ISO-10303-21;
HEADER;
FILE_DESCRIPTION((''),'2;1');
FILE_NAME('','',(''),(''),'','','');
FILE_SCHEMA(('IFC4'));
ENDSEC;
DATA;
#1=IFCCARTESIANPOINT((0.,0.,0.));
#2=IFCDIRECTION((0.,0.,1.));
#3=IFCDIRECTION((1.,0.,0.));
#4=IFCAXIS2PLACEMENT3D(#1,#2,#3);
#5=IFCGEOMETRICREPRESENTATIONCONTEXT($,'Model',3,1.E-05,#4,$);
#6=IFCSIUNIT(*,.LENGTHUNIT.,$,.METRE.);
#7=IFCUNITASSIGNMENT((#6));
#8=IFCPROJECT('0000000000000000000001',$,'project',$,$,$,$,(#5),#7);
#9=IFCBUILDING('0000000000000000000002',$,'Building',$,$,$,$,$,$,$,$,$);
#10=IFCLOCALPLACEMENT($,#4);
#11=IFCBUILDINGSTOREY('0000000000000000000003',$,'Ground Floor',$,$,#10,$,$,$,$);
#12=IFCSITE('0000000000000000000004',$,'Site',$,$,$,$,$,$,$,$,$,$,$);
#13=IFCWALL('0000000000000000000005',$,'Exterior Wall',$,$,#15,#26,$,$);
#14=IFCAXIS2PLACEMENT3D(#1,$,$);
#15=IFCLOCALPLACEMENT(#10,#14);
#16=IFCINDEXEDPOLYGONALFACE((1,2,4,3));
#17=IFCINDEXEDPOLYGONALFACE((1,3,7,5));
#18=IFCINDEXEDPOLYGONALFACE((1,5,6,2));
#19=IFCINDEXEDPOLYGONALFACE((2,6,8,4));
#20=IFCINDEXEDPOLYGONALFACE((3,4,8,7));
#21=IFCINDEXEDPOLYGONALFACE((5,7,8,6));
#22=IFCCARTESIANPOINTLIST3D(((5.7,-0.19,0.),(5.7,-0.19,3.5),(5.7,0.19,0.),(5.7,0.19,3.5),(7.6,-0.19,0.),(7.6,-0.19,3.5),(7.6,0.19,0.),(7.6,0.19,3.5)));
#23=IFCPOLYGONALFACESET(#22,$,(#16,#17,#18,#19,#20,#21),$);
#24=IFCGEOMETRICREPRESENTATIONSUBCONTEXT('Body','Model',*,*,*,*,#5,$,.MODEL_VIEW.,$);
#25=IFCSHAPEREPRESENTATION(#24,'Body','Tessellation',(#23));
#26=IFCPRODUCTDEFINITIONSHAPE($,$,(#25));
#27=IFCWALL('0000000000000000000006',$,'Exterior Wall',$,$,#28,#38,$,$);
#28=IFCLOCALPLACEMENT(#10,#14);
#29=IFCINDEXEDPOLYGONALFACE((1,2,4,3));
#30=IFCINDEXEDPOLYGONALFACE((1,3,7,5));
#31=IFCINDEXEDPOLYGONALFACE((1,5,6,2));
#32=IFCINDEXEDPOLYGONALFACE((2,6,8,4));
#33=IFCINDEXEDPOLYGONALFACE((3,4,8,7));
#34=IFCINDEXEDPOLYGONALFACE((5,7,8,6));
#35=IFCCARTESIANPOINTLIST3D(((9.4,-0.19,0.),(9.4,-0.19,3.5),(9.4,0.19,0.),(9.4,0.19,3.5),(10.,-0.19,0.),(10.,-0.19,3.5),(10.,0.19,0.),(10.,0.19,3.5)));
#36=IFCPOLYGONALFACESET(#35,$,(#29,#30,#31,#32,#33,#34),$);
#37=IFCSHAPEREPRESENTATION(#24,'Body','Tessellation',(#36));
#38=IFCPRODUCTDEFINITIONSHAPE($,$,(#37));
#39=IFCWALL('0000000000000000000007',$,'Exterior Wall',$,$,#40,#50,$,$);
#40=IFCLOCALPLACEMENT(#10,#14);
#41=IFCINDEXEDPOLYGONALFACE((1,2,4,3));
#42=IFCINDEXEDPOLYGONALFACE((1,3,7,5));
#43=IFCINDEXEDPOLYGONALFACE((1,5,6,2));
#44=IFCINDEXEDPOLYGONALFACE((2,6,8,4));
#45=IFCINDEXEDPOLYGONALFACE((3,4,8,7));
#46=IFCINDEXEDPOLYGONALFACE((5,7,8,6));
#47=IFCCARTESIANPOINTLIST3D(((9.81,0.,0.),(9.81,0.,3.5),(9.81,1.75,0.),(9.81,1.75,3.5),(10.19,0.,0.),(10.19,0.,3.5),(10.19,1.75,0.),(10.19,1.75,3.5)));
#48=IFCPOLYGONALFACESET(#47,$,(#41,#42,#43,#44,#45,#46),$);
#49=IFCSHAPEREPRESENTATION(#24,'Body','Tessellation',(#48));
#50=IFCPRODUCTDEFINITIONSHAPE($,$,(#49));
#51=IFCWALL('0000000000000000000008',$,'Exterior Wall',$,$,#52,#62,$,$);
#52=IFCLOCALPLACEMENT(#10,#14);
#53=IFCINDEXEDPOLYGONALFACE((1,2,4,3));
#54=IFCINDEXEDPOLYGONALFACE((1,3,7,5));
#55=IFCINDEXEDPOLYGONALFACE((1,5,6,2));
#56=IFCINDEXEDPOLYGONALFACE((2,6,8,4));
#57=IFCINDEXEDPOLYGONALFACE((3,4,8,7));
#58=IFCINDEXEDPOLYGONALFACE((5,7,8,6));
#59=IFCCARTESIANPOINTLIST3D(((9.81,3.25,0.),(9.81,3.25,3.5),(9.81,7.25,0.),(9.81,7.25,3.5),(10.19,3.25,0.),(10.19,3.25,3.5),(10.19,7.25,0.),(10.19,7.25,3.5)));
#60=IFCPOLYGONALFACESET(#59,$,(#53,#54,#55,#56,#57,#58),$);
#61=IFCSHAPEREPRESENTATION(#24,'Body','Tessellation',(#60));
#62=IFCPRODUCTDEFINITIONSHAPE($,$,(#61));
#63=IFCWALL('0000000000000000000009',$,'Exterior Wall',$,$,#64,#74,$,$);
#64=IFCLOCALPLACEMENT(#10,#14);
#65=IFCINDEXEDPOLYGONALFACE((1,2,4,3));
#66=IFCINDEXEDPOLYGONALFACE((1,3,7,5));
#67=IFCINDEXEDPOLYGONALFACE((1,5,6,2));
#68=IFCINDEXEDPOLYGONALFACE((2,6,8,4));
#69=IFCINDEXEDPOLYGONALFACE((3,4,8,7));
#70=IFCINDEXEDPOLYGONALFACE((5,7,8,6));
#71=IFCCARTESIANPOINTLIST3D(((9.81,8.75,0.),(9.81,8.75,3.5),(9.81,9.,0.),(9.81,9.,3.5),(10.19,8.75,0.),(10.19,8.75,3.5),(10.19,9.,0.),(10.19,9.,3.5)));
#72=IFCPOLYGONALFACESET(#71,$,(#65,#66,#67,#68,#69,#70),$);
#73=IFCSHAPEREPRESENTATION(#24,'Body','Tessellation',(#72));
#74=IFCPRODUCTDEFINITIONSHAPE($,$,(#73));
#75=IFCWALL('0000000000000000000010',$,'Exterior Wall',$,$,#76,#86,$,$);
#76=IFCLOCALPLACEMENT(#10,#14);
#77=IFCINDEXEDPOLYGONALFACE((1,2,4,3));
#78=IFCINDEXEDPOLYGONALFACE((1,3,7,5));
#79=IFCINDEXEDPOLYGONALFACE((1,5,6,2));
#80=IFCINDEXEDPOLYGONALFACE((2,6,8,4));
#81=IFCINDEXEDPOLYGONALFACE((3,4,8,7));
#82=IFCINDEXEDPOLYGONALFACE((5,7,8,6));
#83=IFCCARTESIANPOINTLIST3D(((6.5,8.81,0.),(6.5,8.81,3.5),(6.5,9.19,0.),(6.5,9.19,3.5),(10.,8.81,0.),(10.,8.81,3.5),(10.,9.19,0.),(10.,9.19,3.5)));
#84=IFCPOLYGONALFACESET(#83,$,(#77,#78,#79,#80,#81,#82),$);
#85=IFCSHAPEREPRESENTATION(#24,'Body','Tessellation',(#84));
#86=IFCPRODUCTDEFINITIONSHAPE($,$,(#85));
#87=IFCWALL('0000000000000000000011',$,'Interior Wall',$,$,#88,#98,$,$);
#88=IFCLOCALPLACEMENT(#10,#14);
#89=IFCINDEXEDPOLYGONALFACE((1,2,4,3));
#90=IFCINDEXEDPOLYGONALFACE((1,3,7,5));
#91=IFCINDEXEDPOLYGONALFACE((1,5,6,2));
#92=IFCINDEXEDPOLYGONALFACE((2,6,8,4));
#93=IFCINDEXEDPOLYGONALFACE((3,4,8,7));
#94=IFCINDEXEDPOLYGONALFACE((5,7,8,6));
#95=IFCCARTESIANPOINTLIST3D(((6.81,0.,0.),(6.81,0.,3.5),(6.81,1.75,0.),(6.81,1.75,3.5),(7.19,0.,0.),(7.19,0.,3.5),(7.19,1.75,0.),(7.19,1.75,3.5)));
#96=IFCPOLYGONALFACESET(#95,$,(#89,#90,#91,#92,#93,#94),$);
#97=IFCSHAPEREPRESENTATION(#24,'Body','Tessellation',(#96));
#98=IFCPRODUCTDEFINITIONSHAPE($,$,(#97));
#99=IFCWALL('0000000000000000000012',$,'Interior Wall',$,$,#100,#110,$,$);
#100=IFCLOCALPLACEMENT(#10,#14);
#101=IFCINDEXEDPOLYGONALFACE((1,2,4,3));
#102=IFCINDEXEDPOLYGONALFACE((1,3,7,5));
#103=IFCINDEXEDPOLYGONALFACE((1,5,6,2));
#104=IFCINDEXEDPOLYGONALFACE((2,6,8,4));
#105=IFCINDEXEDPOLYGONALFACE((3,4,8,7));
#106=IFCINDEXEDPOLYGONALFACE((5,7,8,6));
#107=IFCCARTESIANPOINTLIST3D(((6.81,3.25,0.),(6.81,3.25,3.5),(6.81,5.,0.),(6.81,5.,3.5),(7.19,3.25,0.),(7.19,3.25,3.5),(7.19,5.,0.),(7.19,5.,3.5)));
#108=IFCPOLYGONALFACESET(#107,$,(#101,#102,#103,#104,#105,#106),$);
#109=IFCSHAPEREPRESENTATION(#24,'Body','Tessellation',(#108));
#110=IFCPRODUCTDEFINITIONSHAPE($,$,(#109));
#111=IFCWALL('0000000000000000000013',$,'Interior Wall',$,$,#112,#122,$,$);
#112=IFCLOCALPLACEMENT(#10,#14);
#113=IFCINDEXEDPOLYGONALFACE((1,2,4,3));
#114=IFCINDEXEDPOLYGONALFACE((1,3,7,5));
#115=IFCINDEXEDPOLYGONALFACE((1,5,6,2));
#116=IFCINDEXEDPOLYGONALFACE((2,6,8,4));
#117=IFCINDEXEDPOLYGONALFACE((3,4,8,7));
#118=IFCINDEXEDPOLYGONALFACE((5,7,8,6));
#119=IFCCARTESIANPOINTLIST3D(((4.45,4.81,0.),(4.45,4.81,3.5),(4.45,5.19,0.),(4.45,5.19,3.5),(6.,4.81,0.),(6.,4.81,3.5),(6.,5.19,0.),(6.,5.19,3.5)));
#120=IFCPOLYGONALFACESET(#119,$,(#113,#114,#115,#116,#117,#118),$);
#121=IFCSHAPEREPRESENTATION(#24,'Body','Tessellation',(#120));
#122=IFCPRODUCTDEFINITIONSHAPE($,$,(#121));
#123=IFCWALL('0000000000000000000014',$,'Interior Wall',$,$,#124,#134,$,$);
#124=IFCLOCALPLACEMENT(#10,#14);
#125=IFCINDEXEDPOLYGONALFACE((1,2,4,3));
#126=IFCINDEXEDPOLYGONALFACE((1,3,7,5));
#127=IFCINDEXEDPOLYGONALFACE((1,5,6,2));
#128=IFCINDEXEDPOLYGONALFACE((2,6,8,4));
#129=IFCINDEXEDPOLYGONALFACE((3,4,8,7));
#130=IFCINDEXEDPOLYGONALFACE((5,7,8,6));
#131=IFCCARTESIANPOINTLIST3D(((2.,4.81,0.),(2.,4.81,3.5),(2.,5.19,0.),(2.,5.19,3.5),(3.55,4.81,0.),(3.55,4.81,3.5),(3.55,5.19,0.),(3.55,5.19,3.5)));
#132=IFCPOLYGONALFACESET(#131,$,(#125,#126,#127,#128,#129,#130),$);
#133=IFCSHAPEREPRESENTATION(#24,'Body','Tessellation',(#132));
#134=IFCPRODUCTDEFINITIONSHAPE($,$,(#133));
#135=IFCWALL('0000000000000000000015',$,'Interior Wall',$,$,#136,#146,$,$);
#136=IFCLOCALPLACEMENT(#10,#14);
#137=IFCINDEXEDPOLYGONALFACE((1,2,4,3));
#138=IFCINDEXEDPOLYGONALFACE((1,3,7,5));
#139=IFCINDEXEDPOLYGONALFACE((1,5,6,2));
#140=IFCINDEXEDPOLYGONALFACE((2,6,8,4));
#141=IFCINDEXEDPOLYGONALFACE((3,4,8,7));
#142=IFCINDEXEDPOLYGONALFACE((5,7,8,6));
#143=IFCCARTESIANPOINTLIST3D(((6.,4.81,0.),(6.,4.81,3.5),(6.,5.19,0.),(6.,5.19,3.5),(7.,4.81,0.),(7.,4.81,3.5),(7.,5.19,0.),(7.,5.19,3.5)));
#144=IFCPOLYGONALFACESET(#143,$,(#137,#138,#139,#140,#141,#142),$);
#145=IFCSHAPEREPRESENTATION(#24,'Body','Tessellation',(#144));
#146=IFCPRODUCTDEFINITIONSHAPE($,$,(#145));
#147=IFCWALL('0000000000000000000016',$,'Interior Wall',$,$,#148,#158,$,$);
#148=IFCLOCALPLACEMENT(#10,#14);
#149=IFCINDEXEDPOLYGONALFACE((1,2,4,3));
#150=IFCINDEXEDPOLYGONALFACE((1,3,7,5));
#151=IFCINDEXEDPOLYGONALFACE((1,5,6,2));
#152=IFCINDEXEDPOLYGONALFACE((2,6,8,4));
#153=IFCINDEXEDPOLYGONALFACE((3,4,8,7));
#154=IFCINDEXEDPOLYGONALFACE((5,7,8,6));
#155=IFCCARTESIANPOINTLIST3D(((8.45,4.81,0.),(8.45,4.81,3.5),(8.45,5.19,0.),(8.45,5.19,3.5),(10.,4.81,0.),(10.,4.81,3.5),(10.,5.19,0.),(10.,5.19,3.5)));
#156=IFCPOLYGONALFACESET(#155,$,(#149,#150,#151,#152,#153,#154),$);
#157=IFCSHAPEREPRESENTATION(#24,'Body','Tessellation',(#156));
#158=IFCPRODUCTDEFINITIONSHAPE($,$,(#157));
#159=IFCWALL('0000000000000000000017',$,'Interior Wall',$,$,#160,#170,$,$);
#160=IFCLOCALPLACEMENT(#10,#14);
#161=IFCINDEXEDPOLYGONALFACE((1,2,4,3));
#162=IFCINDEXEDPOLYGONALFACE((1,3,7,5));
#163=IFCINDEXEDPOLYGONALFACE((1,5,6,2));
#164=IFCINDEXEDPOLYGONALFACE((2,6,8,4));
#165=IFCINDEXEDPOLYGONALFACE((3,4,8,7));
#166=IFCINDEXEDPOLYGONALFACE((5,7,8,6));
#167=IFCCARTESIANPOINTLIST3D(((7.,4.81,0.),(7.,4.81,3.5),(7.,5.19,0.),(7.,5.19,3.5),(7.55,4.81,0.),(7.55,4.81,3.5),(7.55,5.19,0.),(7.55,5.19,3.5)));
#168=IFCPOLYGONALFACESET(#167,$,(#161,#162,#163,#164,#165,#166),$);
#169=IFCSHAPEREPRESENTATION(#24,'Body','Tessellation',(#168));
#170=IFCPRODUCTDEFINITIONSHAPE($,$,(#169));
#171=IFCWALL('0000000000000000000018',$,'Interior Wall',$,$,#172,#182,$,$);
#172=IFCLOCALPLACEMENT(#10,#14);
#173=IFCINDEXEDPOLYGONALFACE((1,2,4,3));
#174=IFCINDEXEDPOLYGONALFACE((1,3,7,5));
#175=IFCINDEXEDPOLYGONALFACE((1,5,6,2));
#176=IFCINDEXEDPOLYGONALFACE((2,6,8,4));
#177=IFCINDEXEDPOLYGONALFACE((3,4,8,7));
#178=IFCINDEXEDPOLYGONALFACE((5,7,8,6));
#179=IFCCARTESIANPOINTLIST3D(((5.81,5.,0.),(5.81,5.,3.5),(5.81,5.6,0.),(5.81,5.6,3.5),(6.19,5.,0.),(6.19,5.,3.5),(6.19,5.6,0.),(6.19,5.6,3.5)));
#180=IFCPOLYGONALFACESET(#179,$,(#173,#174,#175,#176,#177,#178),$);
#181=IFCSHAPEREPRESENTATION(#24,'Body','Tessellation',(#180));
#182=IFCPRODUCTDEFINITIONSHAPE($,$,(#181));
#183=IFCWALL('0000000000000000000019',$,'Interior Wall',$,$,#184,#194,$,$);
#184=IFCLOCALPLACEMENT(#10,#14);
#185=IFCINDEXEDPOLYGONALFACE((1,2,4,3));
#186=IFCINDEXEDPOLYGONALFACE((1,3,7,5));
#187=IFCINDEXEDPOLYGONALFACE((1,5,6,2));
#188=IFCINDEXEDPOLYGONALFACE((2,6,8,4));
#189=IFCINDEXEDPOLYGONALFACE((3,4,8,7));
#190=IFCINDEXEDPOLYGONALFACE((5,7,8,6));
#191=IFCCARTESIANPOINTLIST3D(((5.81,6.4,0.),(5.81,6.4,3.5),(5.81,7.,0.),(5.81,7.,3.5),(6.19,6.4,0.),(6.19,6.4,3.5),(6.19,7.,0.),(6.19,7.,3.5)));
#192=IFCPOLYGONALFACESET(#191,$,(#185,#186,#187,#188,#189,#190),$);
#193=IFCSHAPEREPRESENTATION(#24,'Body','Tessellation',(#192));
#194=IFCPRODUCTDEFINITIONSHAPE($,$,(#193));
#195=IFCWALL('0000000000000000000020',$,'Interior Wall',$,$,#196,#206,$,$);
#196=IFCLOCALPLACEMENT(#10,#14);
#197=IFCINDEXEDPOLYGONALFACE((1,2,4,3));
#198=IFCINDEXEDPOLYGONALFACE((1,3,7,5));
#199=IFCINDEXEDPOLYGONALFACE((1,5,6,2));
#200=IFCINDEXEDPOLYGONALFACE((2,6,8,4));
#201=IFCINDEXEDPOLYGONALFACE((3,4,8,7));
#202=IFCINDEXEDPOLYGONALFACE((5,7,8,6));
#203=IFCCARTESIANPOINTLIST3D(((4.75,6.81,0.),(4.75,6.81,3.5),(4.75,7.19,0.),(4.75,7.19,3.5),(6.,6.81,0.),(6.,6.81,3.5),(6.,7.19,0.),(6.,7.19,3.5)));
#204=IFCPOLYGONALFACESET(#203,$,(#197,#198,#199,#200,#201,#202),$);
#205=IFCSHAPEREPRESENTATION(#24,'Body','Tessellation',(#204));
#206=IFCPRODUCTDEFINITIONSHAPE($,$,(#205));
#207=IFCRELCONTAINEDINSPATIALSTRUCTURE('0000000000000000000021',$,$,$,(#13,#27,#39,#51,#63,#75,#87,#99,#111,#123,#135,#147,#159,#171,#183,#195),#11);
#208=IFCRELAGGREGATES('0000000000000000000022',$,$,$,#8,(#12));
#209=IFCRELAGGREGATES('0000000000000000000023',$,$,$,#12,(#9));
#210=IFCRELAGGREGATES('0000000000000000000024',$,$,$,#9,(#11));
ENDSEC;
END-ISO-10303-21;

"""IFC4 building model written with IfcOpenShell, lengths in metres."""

from ifc_helpers import new_model, si_unit, frame, origin_with_axes, place, context, subcontext, project, spatial, indexed_curve, outline, extrude, element, save


model = new_model("IFC4")

# Units and contexts
model_context = context("Model", 3, precision=1e-05, world=origin_with_axes())
body_context = subcontext(model_context, "Body", "Model", "MODEL_VIEW")
ifc_project = project(units=[si_unit("LENGTHUNIT", "METRE")], contexts=[model_context])

# Site, building, storey
site = spatial("IfcSite", under=ifc_project, Name="Site")
building = spatial("IfcBuilding", under=site, Name="Building")
storey_placement = place(None, origin_with_axes())
storey = spatial("IfcBuildingStorey", under=building, at=storey_placement, Name="Ground Floor")

# Walls
wall_1_placement = place(storey_placement, frame((5.7, 0.0, 0.0), z_axis=(0.0, 0.0, 1.0), x_axis=(1.0, 0.0, 0.0)))
element("IfcWall", 1, at=wall_1_placement, inside=storey, Name="Exterior Wall", context=body_context, shape_type="SweptSolid", body=[
    extrude(outline(indexed_curve([(0.0, 0.0), (0.0, 0.38), (1.9, 0.38), (1.9, 0.0), (0.0, 0.0)], self_intersect=False)), frame((0.0, -0.19, 0.0), z_axis=(0.0, 0.0, 1.0), x_axis=(1.0, 0.0, 0.0)), (0.0, 0.0, 1.0), 3.5),
])
wall_2_placement = place(storey_placement, frame((9.4, 0.0, 0.0), z_axis=(0.0, 0.0, 1.0), x_axis=(1.0, 0.0, 0.0)))
element("IfcWall", 2, at=wall_2_placement, inside=storey, Name="Exterior Wall", context=body_context, shape_type="SweptSolid", body=[
    extrude(outline(indexed_curve([(0.0, 0.0), (0.0, 0.38), (0.6, 0.38), (0.6, 0.0), (0.0, 0.0)], self_intersect=False)), frame((0.0, -0.19, 0.0), z_axis=(0.0, 0.0, 1.0), x_axis=(1.0, 0.0, 0.0)), (0.0, 0.0, 1.0), 3.5),
])
wall_3_placement = place(storey_placement, frame((10.0, 0.0, 0.0), z_axis=(0.0, 0.0, 1.0), x_axis=(0.0, 1.0, 0.0)))
element("IfcWall", 3, at=wall_3_placement, inside=storey, Name="Exterior Wall", context=body_context, shape_type="SweptSolid", body=[
    extrude(outline(indexed_curve([(0.0, 0.0), (0.0, 0.38), (1.75, 0.38), (1.75, 0.0), (0.0, 0.0)], self_intersect=False)), frame((0.0, -0.19, 0.0), z_axis=(0.0, 0.0, 1.0), x_axis=(1.0, 0.0, 0.0)), (0.0, 0.0, 1.0), 3.5),
])
wall_4_placement = place(storey_placement, frame((10.0, 3.25, 0.0), z_axis=(0.0, 0.0, 1.0), x_axis=(0.0, 1.0, 0.0)))
element("IfcWall", 4, at=wall_4_placement, inside=storey, Name="Exterior Wall", context=body_context, shape_type="SweptSolid", body=[
    extrude(outline(indexed_curve([(0.0, 0.0), (0.0, 0.38), (4.0, 0.38), (4.0, 0.0), (0.0, 0.0)], self_intersect=False)), frame((0.0, -0.19, 0.0), z_axis=(0.0, 0.0, 1.0), x_axis=(1.0, 0.0, 0.0)), (0.0, 0.0, 1.0), 3.5),
])
wall_5_placement = place(storey_placement, frame((10.0, 8.75, 0.0), z_axis=(0.0, 0.0, 1.0), x_axis=(0.0, 1.0, 0.0)))
element("IfcWall", 5, at=wall_5_placement, inside=storey, Name="Exterior Wall", context=body_context, shape_type="SweptSolid", body=[
    extrude(outline(indexed_curve([(0.0, 0.0), (0.0, 0.38), (0.25, 0.38), (0.25, 0.0), (0.0, 0.0)], self_intersect=False)), frame((0.0, -0.19, 0.0), z_axis=(0.0, 0.0, 1.0), x_axis=(1.0, 0.0, 0.0)), (0.0, 0.0, 1.0), 3.5),
])
wall_6_placement = place(storey_placement, frame((10.0, 9.0, 0.0), z_axis=(0.0, 0.0, 1.0), x_axis=(-1.0, 0.0, 0.0)))
element("IfcWall", 6, at=wall_6_placement, inside=storey, Name="Exterior Wall", context=body_context, shape_type="SweptSolid", body=[
    extrude(outline(indexed_curve([(0.0, 0.0), (0.0, 0.38), (3.5, 0.38), (3.5, 0.0), (0.0, 0.0)], self_intersect=False)), frame((0.0, -0.19, 0.0), z_axis=(0.0, 0.0, 1.0), x_axis=(1.0, 0.0, 0.0)), (0.0, 0.0, 1.0), 3.5),
])
for number, where, z_axis, x_axis, name in (
    (7, (7.0, 0.0, 0.0), (0.0, 0.0, 1.0), (0.0, 1.0, 0.0), "Interior Wall"),
    (8, (7.0, 3.25, 0.0), (0.0, 0.0, 1.0), (0.0, 1.0, 0.0), "Interior Wall"),
):
    element("IfcWall", number, at=place(storey_placement, frame(where, z_axis=z_axis, x_axis=x_axis)), inside=storey, Name=name, context=body_context, shape_type="SweptSolid", body=[
        extrude(outline(indexed_curve([(0.0, 0.0), (0.0, 0.38), (1.75, 0.38), (1.75, 0.0), (0.0, 0.0)], self_intersect=False)), frame((0.0, -0.19, 0.0), z_axis=(0.0, 0.0, 1.0), x_axis=(1.0, 0.0, 0.0)), (0.0, 0.0, 1.0), 3.5),
    ])
for number, where, z_axis, x_axis, name in (
    (9, (6.0, 5.0, 0.0), (0.0, 0.0, 1.0), (-1.0, 0.0, 0.0), "Interior Wall"),
    (10, (3.55, 5.0, 0.0), (0.0, 0.0, 1.0), (-1.0, 0.0, 0.0), "Interior Wall"),
):
    element("IfcWall", number, at=place(storey_placement, frame(where, z_axis=z_axis, x_axis=x_axis)), inside=storey, Name=name, context=body_context, shape_type="SweptSolid", body=[
        extrude(outline(indexed_curve([(0.0, 0.0), (0.0, 0.38), (1.55, 0.38), (1.55, 0.0), (0.0, 0.0)], self_intersect=False)), frame((0.0, -0.19, 0.0), z_axis=(0.0, 0.0, 1.0), x_axis=(1.0, 0.0, 0.0)), (0.0, 0.0, 1.0), 3.5),
    ])
wall_7_placement = place(storey_placement, frame((7.0, 5.0, 0.0), z_axis=(0.0, 0.0, 1.0), x_axis=(-1.0, 0.0, 0.0)))
element("IfcWall", 11, at=wall_7_placement, inside=storey, Name="Interior Wall", context=body_context, shape_type="SweptSolid", body=[
    extrude(outline(indexed_curve([(0.0, 0.0), (0.0, 0.38), (1.0, 0.38), (1.0, 0.0), (0.0, 0.0)], self_intersect=False)), frame((0.0, -0.19, 0.0), z_axis=(0.0, 0.0, 1.0), x_axis=(1.0, 0.0, 0.0)), (0.0, 0.0, 1.0), 3.5),
])
wall_8_placement = place(storey_placement, frame((10.0, 5.0, 0.0), z_axis=(0.0, 0.0, 1.0), x_axis=(-1.0, 0.0, 0.0)))
element("IfcWall", 12, at=wall_8_placement, inside=storey, Name="Interior Wall", context=body_context, shape_type="SweptSolid", body=[
    extrude(outline(indexed_curve([(0.0, 0.0), (0.0, 0.38), (1.55, 0.38), (1.55, 0.0), (0.0, 0.0)], self_intersect=False)), frame((0.0, -0.19, 0.0), z_axis=(0.0, 0.0, 1.0), x_axis=(1.0, 0.0, 0.0)), (0.0, 0.0, 1.0), 3.5),
])
wall_9_placement = place(storey_placement, frame((7.55, 5.0, 0.0), z_axis=(0.0, 0.0, 1.0), x_axis=(-1.0, 0.0, 0.0)))
element("IfcWall", 13, at=wall_9_placement, inside=storey, Name="Interior Wall", context=body_context, shape_type="SweptSolid", body=[
    extrude(outline(indexed_curve([(0.0, 0.0), (0.0, 0.38), (0.55, 0.38), (0.55, 0.0), (0.0, 0.0)], self_intersect=False)), frame((0.0, -0.19, 0.0), z_axis=(0.0, 0.0, 1.0), x_axis=(1.0, 0.0, 0.0)), (0.0, 0.0, 1.0), 3.5),
])
for number, where, z_axis, x_axis, name in (
    (14, (6.0, 5.0, 0.0), (0.0, 0.0, 1.0), (0.0, 1.0, 0.0), "Interior Wall"),
    (15, (6.0, 6.4, 0.0), (0.0, 0.0, 1.0), (0.0, 1.0, 0.0), "Interior Wall"),
):
    element("IfcWall", number, at=place(storey_placement, frame(where, z_axis=z_axis, x_axis=x_axis)), inside=storey, Name=name, context=body_context, shape_type="SweptSolid", body=[
        extrude(outline(indexed_curve([(0.0, 0.0), (0.0, 0.38), (0.6, 0.38), (0.6, 0.0), (0.0, 0.0)], self_intersect=False)), frame((0.0, -0.19, 0.0), z_axis=(0.0, 0.0, 1.0), x_axis=(1.0, 0.0, 0.0)), (0.0, 0.0, 1.0), 3.5),
    ])
for number, where, z_axis, x_axis, name in (
    (16, (6.0, 7.0, 0.0), (0.0, 0.0, 1.0), (-1.0, 0.0, 0.0), "Interior Wall"),
):
    element("IfcWall", number, at=place(storey_placement, frame(where, z_axis=z_axis, x_axis=x_axis)), inside=storey, Name=name, context=body_context, shape_type="SweptSolid", body=[
        extrude(outline(indexed_curve([(0.0, 0.0), (0.0, 0.38), (1.25, 0.38), (1.25, 0.0), (0.0, 0.0)], self_intersect=False)), frame((0.0, -0.19, 0.0), z_axis=(0.0, 0.0, 1.0), x_axis=(1.0, 0.0, 0.0)), (0.0, 0.0, 1.0), 3.5),
    ])

save(model, "model.ifc")
